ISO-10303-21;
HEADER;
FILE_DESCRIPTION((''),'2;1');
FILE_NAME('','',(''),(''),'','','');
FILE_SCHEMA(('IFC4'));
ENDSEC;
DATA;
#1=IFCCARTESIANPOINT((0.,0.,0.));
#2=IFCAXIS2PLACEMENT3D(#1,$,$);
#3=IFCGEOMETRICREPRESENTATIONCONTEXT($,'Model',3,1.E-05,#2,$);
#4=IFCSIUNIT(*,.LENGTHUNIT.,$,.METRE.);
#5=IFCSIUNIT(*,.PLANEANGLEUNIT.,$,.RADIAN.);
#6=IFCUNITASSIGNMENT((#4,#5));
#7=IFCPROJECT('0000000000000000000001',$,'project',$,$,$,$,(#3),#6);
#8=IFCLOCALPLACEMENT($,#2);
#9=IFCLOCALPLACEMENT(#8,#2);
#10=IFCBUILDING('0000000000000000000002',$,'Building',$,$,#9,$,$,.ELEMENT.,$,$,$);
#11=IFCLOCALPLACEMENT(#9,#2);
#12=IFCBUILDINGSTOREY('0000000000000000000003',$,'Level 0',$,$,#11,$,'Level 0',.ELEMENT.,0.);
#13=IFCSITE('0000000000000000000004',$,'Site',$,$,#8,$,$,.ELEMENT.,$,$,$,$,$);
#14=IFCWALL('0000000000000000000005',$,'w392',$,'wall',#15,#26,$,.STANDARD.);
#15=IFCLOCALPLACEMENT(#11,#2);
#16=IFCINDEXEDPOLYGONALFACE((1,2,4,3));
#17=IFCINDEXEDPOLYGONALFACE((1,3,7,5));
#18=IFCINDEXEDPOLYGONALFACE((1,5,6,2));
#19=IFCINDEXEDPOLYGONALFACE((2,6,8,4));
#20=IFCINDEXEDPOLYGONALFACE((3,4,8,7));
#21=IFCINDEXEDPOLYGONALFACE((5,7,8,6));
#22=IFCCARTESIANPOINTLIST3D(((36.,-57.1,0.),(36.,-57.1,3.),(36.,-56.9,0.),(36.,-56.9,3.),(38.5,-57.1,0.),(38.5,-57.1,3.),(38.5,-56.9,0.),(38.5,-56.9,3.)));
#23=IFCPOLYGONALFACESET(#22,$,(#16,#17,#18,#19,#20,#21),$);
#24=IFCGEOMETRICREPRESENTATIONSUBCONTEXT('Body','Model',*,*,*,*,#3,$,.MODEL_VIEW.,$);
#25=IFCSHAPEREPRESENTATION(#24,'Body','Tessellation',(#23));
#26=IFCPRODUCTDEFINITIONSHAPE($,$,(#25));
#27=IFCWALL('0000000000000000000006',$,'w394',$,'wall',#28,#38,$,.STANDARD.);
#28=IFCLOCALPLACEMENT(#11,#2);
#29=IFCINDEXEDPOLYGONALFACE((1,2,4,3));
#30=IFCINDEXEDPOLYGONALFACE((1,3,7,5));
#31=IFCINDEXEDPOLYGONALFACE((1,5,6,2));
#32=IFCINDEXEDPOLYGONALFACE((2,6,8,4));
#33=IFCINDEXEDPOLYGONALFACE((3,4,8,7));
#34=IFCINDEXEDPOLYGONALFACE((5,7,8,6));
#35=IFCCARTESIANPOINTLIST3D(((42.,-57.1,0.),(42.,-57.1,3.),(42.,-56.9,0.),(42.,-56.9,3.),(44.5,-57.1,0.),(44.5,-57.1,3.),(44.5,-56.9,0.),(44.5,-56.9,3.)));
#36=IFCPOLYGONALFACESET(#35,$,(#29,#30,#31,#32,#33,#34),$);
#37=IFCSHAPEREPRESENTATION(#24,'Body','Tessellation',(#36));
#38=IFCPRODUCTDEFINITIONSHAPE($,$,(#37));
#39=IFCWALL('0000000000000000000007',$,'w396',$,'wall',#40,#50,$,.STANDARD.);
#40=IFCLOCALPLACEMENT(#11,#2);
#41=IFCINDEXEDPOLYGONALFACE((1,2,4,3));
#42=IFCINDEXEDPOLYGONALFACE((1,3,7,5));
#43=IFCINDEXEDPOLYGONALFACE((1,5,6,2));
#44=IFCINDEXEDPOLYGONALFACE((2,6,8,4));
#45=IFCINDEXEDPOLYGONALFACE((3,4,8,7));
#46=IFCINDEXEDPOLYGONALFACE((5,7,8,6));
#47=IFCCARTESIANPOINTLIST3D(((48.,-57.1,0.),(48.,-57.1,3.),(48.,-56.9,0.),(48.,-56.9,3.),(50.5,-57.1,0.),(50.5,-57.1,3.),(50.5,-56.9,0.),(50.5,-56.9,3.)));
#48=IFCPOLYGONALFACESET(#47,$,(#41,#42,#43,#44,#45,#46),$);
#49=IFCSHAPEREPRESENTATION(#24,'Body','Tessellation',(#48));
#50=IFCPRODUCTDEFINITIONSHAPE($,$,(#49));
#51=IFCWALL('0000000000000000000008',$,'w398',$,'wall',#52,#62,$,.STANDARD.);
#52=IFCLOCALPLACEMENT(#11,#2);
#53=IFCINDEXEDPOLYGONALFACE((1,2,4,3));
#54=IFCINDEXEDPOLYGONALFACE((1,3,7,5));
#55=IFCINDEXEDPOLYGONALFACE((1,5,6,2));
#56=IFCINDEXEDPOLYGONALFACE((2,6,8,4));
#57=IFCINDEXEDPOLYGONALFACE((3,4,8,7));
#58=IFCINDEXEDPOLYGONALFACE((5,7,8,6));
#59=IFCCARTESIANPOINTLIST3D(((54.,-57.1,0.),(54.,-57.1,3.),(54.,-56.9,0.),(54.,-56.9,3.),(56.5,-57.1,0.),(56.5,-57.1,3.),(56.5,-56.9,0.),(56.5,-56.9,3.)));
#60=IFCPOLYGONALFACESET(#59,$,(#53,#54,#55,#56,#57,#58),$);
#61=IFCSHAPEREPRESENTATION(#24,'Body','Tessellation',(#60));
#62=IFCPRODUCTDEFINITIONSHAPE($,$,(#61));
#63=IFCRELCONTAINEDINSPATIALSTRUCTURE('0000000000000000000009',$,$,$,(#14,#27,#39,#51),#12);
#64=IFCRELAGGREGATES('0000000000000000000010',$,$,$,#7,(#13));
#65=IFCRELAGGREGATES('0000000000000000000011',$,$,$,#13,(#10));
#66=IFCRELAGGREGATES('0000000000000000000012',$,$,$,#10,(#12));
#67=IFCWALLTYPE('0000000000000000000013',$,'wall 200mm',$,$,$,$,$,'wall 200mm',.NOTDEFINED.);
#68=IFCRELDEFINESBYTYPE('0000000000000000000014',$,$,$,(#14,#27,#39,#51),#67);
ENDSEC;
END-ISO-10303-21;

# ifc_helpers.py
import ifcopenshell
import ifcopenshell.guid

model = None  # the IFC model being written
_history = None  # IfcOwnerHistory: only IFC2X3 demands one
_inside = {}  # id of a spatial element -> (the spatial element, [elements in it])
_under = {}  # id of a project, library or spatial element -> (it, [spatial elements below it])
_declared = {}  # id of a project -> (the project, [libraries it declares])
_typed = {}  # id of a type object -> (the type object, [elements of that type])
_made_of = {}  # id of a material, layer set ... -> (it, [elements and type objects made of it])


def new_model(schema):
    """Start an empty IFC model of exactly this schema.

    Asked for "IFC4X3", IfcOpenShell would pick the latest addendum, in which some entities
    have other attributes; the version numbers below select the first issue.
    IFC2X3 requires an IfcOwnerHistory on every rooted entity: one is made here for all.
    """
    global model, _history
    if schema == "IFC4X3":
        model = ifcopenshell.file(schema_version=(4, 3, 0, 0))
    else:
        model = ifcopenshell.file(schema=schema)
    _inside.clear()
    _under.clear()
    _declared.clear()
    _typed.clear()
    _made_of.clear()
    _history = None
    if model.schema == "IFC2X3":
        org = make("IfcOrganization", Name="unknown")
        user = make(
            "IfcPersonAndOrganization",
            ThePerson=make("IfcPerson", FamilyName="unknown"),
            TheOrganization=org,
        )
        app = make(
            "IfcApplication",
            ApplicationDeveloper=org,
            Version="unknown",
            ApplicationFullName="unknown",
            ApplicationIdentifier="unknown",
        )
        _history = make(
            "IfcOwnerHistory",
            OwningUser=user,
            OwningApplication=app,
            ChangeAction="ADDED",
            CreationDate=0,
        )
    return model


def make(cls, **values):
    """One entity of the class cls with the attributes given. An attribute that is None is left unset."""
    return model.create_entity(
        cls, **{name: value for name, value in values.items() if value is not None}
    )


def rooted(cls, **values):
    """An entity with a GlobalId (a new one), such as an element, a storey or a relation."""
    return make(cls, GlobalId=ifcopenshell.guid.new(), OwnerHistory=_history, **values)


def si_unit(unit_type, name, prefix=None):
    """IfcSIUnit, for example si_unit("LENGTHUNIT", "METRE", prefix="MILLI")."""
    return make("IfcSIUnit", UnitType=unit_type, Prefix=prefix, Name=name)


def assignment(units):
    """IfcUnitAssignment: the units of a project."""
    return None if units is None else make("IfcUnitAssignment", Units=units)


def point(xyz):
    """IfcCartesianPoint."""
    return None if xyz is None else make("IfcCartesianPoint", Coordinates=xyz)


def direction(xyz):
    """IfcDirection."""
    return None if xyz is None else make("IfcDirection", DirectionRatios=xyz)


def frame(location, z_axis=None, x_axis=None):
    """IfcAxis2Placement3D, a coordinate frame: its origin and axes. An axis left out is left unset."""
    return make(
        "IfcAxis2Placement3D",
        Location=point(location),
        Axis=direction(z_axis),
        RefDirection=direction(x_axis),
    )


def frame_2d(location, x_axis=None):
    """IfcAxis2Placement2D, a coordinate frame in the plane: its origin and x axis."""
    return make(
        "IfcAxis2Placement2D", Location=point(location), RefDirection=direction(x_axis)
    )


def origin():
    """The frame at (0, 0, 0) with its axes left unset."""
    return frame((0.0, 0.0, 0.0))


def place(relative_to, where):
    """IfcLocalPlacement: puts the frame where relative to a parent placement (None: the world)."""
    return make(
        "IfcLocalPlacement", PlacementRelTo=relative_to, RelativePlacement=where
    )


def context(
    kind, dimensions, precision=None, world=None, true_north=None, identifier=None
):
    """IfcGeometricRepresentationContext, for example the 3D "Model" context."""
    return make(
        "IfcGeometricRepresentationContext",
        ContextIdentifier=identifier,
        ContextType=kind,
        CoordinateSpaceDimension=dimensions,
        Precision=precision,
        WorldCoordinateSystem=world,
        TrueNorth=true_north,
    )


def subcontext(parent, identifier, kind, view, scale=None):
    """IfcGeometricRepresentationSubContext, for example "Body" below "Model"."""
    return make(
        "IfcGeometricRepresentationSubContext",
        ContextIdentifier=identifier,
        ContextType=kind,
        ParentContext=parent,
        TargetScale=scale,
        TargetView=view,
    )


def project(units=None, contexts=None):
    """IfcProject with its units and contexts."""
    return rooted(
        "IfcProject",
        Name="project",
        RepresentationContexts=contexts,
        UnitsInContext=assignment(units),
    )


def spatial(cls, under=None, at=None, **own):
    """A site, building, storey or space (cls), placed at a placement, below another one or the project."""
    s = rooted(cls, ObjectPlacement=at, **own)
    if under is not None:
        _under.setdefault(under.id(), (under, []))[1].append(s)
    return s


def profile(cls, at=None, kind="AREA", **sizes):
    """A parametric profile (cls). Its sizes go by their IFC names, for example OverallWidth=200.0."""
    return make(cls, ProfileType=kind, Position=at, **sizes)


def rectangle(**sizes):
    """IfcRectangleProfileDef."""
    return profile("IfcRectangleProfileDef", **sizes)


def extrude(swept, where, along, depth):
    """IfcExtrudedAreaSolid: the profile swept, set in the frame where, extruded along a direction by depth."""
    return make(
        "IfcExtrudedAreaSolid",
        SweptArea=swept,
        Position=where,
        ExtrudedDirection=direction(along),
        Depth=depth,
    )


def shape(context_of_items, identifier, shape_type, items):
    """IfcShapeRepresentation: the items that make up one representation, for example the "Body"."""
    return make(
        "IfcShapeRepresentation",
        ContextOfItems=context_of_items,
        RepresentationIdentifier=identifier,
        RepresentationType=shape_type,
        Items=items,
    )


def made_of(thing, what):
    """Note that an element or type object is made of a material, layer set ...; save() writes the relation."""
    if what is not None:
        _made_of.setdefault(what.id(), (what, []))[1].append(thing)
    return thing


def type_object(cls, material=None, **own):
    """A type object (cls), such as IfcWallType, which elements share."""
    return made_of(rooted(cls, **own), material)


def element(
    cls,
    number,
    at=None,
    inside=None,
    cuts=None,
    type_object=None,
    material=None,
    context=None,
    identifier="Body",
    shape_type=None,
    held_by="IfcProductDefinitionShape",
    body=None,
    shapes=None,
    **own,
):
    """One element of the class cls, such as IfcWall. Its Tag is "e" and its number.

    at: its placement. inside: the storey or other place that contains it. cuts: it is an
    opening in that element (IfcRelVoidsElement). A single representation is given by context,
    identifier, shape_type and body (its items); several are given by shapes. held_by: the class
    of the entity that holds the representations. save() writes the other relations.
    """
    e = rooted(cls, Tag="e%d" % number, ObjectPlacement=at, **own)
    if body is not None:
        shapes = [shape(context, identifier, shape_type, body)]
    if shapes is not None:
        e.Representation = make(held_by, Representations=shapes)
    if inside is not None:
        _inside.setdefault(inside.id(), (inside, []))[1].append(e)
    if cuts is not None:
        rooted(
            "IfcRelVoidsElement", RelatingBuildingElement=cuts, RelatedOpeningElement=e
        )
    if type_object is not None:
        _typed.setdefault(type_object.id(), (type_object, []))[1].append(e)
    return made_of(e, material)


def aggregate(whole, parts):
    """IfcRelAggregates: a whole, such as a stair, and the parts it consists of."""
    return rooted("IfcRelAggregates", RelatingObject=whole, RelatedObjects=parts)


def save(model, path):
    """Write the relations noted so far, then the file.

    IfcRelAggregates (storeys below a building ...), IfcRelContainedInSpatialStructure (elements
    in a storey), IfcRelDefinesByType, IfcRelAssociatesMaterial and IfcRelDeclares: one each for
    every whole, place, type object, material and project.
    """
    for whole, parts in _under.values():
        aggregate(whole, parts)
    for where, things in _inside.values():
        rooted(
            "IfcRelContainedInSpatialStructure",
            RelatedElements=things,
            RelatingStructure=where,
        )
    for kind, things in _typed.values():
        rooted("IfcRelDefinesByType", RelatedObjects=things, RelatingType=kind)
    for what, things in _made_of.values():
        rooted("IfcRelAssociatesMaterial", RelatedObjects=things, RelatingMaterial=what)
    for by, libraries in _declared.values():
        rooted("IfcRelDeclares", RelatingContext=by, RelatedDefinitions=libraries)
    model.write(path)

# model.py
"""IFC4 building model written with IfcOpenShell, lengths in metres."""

from ifc_helpers import new_model, si_unit, frame, frame_2d, origin, place, context, subcontext, project, spatial, rectangle, extrude, type_object, element, save


model = new_model("IFC4")

# Units and contexts
model_context = context("Model", 3, precision=1e-05, world=origin())
body_context = subcontext(model_context, "Body", "Model", "MODEL_VIEW")
ifc_project = project(units=[si_unit("LENGTHUNIT", "METRE"), si_unit("PLANEANGLEUNIT", "RADIAN")], contexts=[model_context])

# Site, building, storey
site_placement = place(None, origin())
site = spatial("IfcSite", under=ifc_project, at=site_placement, Name="Site", CompositionType="ELEMENT")
building_placement = place(site_placement, origin())
building = spatial("IfcBuilding", under=site, at=building_placement, Name="Building", CompositionType="ELEMENT")
storey_placement = place(building_placement, origin())
storey = spatial("IfcBuildingStorey", under=building, at=storey_placement, Name="Level 0", LongName="Level 0", CompositionType="ELEMENT", Elevation=0.0)

# Walls
wall_type = type_object("IfcWallType", Name="wall 200mm", ElementType="wall 200mm", PredefinedType="NOTDEFINED")
for number, where, z_axis, x_axis, name in (
    (1, (36.0, -57.0, 0.0), (0.0, 0.0, 1.0), (1.0, 0.0, 0.0), "w392"),
    (2, (42.0, -57.0, 0.0), (0.0, 0.0, 1.0), (1.0, 0.0, 0.0), "w394"),
    (3, (48.0, -57.0, 0.0), (0.0, 0.0, 1.0), (1.0, 0.0, 0.0), "w396"),
    (4, (54.0, -57.0, 0.0), (0.0, 0.0, 1.0), (1.0, 0.0, 0.0), "w398"),
):
    element("IfcWall", number, at=place(storey_placement, frame(where, z_axis=z_axis, x_axis=x_axis)), inside=storey, type_object=wall_type, Name=name, ObjectType="wall", PredefinedType="STANDARD", context=body_context, shape_type="SweptSolid", body=[
        extrude(rectangle(XDim=2.5, YDim=0.2, at=frame_2d((1.25, 0.0))), origin(), (0.0, 0.0, 1.0), 3.0),
    ])

save(model, "model.ifc")
